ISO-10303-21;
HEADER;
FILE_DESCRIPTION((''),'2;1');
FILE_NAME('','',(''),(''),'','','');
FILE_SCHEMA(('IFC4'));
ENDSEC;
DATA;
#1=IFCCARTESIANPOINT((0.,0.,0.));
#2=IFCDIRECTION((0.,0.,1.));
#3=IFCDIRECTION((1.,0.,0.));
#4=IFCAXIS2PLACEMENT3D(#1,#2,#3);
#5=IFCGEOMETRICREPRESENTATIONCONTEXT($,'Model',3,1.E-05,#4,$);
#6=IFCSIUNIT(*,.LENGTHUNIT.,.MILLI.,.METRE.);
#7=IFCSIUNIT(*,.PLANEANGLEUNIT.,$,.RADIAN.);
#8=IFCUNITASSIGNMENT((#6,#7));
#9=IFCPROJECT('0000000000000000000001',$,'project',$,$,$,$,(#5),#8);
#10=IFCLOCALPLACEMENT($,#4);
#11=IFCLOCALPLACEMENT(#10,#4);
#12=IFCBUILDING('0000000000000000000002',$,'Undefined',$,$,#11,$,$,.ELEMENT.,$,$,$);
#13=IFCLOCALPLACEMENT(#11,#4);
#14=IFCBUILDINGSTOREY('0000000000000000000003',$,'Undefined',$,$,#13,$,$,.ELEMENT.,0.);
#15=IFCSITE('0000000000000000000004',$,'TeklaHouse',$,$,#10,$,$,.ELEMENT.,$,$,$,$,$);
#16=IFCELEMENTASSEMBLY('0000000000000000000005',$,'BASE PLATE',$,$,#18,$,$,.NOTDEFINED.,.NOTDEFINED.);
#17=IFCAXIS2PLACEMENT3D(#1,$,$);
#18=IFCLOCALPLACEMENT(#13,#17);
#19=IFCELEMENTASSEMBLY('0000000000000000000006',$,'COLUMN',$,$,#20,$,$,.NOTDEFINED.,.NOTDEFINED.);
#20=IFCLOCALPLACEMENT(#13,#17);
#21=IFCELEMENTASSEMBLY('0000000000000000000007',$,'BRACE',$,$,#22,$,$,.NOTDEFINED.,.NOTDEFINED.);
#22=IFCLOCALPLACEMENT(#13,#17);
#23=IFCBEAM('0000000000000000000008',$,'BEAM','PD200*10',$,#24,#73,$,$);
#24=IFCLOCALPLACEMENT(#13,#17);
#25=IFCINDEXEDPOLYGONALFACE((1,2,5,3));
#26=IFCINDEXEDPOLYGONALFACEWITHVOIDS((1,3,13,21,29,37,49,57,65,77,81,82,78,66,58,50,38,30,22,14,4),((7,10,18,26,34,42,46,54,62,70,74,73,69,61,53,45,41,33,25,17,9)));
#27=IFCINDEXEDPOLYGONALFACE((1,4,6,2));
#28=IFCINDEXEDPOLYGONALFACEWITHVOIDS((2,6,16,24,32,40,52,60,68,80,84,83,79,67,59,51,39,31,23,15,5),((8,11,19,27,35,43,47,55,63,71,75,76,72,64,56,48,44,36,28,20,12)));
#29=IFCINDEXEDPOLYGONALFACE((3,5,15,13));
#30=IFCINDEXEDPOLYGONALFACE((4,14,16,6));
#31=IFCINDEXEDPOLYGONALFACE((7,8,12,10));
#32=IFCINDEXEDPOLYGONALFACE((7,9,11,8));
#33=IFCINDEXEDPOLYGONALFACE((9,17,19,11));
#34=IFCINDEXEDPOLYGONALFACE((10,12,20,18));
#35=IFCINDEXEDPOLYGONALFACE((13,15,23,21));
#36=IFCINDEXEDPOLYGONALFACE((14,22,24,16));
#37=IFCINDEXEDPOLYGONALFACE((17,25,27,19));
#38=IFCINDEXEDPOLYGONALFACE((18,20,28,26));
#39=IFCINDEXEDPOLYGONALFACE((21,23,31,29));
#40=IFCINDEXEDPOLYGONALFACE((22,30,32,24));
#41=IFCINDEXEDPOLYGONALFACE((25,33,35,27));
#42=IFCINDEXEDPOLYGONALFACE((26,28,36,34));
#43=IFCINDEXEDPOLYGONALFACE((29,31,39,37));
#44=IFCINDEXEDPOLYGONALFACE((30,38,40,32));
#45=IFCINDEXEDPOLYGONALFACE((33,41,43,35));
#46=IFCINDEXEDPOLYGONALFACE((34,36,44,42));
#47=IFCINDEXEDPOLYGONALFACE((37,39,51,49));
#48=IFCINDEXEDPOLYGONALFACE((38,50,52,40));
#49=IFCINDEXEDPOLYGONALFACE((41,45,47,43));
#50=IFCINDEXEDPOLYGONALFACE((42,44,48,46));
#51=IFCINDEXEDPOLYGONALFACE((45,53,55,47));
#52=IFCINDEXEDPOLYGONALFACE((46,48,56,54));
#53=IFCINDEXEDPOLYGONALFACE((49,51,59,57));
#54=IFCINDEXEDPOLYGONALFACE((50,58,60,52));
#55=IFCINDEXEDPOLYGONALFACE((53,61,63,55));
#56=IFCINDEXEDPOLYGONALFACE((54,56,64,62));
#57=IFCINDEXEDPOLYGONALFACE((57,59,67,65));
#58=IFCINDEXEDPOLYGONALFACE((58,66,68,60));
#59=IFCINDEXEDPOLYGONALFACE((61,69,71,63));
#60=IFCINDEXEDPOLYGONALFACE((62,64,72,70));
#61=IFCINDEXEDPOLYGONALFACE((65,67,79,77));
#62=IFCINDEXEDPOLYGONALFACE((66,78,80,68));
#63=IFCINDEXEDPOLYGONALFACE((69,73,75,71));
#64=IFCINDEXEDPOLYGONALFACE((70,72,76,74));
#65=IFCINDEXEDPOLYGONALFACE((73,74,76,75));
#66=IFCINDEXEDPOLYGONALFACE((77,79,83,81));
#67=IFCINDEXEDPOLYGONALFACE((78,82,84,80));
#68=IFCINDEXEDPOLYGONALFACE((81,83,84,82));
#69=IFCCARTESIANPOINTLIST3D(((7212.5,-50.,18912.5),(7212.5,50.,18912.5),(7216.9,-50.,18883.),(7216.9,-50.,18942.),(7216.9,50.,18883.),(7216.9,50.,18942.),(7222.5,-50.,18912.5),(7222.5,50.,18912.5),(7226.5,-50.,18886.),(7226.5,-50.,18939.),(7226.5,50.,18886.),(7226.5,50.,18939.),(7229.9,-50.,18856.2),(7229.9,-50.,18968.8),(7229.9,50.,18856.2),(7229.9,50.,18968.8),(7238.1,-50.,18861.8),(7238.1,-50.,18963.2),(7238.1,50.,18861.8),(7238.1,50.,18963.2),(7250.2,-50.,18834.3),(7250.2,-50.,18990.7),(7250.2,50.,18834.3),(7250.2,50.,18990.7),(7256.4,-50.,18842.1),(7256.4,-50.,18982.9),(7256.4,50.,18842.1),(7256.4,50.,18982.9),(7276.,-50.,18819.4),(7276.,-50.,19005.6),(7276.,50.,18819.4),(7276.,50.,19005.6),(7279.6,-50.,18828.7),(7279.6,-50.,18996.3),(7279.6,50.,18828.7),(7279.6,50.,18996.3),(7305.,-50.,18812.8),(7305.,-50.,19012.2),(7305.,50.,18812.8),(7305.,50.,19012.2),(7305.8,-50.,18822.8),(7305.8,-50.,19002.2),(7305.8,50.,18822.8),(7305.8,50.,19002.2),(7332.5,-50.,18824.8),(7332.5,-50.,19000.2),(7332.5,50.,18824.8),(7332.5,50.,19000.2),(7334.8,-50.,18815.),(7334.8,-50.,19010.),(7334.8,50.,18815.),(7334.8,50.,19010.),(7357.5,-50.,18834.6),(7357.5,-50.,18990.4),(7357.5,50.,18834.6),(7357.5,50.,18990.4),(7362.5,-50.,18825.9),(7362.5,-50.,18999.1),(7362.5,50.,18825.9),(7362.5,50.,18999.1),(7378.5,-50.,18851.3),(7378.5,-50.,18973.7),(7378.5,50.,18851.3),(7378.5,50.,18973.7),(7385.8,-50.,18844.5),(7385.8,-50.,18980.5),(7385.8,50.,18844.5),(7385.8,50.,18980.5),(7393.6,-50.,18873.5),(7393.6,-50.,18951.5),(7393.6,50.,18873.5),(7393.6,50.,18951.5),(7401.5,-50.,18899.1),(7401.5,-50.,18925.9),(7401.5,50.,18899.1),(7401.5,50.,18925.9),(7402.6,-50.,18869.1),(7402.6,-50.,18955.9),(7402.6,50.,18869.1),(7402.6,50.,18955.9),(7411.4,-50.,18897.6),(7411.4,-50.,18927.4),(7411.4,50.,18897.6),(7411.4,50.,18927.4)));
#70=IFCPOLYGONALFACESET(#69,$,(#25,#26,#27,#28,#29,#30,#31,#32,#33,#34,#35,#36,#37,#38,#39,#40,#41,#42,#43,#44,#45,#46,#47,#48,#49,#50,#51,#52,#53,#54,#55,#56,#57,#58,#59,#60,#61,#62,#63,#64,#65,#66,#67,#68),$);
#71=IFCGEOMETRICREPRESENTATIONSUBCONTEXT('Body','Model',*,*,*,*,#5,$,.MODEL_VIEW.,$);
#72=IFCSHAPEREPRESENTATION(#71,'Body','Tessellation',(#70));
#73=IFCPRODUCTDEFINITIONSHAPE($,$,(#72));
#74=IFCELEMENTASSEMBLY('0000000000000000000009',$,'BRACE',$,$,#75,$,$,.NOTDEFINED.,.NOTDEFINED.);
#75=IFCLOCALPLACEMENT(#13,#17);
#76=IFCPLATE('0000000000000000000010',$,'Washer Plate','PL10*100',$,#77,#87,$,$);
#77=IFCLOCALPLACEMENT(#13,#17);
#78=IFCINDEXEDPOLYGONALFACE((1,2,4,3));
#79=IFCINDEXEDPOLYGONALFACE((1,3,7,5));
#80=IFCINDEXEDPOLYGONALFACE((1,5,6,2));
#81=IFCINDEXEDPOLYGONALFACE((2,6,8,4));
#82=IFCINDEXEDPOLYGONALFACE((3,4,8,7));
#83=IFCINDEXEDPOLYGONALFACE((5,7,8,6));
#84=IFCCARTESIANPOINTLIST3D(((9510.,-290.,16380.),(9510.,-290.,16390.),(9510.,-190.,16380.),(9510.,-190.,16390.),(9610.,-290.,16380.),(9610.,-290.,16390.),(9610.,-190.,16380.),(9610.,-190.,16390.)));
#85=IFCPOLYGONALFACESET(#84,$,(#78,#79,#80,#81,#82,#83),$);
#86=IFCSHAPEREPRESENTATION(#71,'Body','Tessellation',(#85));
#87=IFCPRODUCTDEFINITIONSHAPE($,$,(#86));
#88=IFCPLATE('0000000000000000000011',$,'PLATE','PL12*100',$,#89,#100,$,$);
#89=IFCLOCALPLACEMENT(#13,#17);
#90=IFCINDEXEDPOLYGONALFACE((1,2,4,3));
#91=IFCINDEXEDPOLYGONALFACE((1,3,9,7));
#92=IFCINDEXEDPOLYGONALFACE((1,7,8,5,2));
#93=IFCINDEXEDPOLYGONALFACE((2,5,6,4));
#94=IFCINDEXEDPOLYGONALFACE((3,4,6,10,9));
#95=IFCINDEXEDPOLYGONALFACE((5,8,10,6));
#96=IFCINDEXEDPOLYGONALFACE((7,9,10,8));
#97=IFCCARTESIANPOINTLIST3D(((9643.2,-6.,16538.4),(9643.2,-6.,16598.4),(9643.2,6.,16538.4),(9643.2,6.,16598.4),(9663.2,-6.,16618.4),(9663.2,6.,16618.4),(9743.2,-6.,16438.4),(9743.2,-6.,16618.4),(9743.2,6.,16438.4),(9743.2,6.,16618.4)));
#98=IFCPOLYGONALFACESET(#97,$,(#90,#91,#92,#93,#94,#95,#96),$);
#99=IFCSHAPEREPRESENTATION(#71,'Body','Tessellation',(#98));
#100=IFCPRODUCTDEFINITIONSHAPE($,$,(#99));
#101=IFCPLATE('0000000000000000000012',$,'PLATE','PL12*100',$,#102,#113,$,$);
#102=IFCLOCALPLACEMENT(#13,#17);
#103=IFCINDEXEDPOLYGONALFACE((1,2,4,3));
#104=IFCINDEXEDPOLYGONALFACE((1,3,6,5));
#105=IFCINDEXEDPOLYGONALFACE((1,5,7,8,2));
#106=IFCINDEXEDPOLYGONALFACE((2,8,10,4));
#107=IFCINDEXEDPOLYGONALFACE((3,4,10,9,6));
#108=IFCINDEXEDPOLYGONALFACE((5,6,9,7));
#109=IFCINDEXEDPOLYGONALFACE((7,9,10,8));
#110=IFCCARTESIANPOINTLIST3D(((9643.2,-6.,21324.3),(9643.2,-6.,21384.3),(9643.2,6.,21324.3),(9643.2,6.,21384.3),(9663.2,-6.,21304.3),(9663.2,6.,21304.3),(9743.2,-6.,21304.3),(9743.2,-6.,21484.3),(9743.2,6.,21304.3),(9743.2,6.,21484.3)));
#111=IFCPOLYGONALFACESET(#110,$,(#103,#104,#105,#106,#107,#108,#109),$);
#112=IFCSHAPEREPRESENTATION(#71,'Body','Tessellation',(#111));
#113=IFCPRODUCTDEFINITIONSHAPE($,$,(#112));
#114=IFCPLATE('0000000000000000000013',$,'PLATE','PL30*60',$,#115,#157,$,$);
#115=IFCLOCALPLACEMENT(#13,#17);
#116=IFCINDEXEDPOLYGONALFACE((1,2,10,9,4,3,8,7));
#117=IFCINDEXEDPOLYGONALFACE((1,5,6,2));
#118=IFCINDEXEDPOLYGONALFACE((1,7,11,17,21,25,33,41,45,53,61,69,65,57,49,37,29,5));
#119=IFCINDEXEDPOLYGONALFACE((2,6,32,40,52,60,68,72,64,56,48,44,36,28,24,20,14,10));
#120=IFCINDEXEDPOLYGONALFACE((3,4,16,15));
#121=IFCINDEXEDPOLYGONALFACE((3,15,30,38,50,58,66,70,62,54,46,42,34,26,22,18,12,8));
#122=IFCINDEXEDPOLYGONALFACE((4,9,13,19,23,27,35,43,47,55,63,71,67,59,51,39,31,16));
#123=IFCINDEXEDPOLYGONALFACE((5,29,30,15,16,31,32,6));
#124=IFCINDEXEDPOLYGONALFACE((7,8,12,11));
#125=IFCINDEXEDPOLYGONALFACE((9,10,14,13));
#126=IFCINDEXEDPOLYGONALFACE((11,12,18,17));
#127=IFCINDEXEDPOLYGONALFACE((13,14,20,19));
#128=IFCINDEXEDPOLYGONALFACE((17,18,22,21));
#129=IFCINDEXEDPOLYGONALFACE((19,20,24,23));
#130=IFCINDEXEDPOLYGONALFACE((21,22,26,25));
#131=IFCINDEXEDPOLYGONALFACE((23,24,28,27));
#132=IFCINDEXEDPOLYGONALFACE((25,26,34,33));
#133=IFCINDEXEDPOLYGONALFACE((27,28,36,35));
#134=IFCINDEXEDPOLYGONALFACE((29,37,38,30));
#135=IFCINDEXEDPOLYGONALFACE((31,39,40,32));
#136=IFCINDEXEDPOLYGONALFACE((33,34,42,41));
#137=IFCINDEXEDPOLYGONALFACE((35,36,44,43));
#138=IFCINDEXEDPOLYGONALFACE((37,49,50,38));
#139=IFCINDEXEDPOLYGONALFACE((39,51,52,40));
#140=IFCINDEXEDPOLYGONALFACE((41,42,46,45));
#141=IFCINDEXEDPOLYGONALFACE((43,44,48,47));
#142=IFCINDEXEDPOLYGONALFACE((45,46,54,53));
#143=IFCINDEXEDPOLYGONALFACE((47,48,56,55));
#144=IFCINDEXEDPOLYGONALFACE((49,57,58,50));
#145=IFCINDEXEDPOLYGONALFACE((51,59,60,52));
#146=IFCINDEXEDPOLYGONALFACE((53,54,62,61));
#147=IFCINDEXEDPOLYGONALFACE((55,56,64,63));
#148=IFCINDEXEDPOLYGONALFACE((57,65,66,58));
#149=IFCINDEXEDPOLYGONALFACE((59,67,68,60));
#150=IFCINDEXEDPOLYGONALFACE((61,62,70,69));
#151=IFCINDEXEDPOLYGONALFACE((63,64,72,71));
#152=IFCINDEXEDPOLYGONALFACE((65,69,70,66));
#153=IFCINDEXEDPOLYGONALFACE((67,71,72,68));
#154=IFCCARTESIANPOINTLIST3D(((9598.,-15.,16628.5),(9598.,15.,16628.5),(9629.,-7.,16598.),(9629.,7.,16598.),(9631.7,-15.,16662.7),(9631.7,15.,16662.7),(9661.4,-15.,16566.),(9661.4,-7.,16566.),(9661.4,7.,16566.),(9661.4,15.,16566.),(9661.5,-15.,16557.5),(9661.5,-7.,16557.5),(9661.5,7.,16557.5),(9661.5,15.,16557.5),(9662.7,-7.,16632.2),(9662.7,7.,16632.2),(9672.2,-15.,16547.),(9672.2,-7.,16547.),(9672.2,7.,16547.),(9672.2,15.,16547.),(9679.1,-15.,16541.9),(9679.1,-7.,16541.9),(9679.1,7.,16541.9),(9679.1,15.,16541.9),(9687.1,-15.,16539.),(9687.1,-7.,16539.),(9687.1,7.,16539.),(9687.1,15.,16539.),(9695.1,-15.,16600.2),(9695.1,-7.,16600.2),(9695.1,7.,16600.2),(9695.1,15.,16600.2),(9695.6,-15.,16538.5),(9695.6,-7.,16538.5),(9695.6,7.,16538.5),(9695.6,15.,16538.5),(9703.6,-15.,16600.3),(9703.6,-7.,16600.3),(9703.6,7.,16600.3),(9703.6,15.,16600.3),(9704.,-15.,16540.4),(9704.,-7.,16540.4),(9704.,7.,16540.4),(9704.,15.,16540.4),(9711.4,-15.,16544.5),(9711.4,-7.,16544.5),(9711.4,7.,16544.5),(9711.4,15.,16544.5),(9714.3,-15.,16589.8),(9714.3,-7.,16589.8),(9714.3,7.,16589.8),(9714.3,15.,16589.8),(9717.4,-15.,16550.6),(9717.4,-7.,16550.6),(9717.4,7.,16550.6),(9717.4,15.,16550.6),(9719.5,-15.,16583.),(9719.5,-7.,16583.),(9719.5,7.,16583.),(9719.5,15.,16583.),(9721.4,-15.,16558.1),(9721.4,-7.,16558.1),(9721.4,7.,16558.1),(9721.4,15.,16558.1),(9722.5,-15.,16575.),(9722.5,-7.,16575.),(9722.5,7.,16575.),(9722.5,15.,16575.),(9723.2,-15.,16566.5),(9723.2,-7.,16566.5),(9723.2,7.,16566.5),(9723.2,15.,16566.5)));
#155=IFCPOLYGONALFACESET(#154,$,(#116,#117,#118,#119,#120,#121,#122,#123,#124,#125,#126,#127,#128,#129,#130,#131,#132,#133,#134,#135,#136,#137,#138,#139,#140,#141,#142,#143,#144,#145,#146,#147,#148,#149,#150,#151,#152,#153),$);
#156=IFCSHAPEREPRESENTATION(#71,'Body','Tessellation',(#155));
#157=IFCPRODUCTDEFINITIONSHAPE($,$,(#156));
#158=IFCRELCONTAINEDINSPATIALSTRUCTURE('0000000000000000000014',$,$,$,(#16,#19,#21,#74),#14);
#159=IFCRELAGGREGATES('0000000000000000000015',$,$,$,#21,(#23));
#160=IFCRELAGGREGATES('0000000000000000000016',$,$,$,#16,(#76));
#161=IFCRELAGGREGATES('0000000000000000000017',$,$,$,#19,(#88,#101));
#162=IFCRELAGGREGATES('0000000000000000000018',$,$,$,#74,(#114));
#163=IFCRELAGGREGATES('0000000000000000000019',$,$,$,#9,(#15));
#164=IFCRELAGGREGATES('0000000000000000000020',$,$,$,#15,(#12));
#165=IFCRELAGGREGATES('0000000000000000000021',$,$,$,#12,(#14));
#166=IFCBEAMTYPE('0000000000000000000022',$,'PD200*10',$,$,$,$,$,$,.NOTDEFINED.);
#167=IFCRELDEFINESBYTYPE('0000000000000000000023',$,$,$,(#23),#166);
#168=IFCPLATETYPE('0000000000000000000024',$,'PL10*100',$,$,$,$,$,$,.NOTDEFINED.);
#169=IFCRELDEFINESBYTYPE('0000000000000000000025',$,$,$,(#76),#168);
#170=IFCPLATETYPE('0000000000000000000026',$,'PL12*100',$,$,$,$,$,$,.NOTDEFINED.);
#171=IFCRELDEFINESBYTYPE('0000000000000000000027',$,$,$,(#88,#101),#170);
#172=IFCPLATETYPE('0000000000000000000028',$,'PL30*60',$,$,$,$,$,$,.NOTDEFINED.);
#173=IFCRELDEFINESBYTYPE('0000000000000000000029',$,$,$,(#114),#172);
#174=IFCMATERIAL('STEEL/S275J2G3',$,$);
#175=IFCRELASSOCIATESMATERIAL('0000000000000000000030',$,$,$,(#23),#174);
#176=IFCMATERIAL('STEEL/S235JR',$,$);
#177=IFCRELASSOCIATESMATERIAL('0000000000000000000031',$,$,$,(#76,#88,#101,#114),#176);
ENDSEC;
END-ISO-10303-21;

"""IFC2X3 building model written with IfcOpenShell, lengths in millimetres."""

from ifc_helpers import new_model, si_unit, frame, frame_2d, origin_with_axes, origin_2d_with_axis, place, context, subcontext, project, spatial, polyline, circle_curve, parameter, trimmed, segment, composite_curve, rectangle, hollow_circle, outline, extrude, boolean, material, type_object, element, aggregate, save


model = new_model("IFC2X3")

# Units and contexts
model_context = context("Model", 3, precision=1e-05, world=origin_with_axes())
body_context = subcontext(model_context, "Body", "Model", "MODEL_VIEW")
ifc_project = project(units=[si_unit("LENGTHUNIT", "METRE", prefix="MILLI"), si_unit("PLANEANGLEUNIT", "RADIAN")], contexts=[model_context])

# Site, building, storey
site_placement = place(None, origin_with_axes())
site = spatial("IfcSite", under=ifc_project, at=site_placement, Name="TeklaHouse", CompositionType="ELEMENT")
building_placement = place(site_placement, origin_with_axes())
building = spatial("IfcBuilding", under=site, at=building_placement, Name="Undefined", CompositionType="ELEMENT")
storey_placement = place(building_placement, origin_with_axes())
storey = spatial("IfcBuildingStorey", under=building, at=storey_placement, Name="Undefined", CompositionType="ELEMENT", Elevation=0.0)

# Element assembly
assembly_1_placement = place(storey_placement, origin_with_axes())
assembly_1 = element("IfcElementAssembly", 1, at=assembly_1_placement, inside=storey, Name="BASE PLATE", AssemblyPlace="NOTDEFINED", PredefinedType="NOTDEFINED")
ifc_material_1 = material(Name="STEEL/S235JR")

# Element assembly
assembly_2_placement = place(storey_placement, origin_with_axes())
assembly_2 = element("IfcElementAssembly", 2, at=assembly_2_placement, inside=storey, Name="COLUMN", AssemblyPlace="NOTDEFINED", PredefinedType="NOTDEFINED")

# Element assembly, beam
assembly_3_placement = place(storey_placement, origin_with_axes())
assembly_3 = element("IfcElementAssembly", 3, at=assembly_3_placement, inside=storey, Name="BRACE", AssemblyPlace="NOTDEFINED", PredefinedType="NOTDEFINED")
ifc_material_2 = material(Name="STEEL/S275J2G3")
beam_type_1 = type_object("IfcBeamType", Name="PD200*10", PredefinedType="NOTDEFINED")
beam_1_placement = place(assembly_3_placement, frame((7312.5, -50.0, 18912.5), z_axis=(0.0, 0.0, -1.0), x_axis=(0.0, 1.0, 0.0)))
beam_1 = element("IfcBeam", 4, at=beam_1_placement, type_object=beam_type_1, material=ifc_material_2, Name="BEAM", Description="PD200*10", context=body_context, shape_type="SweptSolid", body=[
    extrude(hollow_circle(Radius=100.0, WallThickness=10.0, at=origin_2d_with_axis()), frame((100.0, 0.0, 0.0), z_axis=(-1.0, 0.0, 0.0), x_axis=(0.0, -1.0, 0.0)), (0.0, 0.0, 1.0), 100.0),
])
aggregate(assembly_3, [beam_1])

# Element assembly
assembly_4_placement = place(storey_placement, origin_with_axes())
assembly_4 = element("IfcElementAssembly", 5, at=assembly_4_placement, inside=storey, Name="BRACE", AssemblyPlace="NOTDEFINED", PredefinedType="NOTDEFINED")

# Plates
plate_type_1 = type_object("IfcPlateType", Name="PL10*100", PredefinedType="NOTDEFINED")
plate_1_placement = place(assembly_1_placement, frame((9610.0, -190.0, 16385.0), z_axis=(0.0, 0.0, -1.0), x_axis=(0.0, -1.0, 0.0)))
plate_1 = element("IfcPlate", 6, at=plate_1_placement, type_object=plate_type_1, material=ifc_material_1, Name="Washer Plate", Description="PL10*100", context=body_context, shape_type="SweptSolid", body=[
    extrude(outline(polyline([(0.0, 0.0), (100.0, 0.0), (100.0, 100.0), (0.0, 100.0), (0.0, 0.0)])), frame((0.0, 0.0, -5.0), z_axis=(0.0, 0.0, 1.0), x_axis=(1.0, 0.0, 0.0)), (0.0, 0.0, 1.0), 10.0),
])
plate_type_2 = type_object("IfcPlateType", Name="PL12*100", PredefinedType="NOTDEFINED")
plate_2_placement = place(assembly_2_placement, frame((9643.2, 0.0, 16538.4), z_axis=(0.0, -1.0, 0.0), x_axis=(0.707107, 0.0, -0.707107)))
plate_2 = element("IfcPlate", 7, at=plate_2_placement, type_object=plate_type_2, material=ifc_material_1, Name="PLATE", Description="PL12*100", context=body_context, shape_type="SweptSolid", body=[
    extrude(outline(polyline([(0.0, 0.0), (141.4, 0.0), (14.1, 127.3), (-42.4, 70.7), (-42.4, 42.4), (0.0, 0.0)])), frame((0.0, 0.0, -6.0), z_axis=(0.0, 0.0, 1.0), x_axis=(1.0, 0.0, 0.0)), (0.0, 0.0, 1.0), 12.0),
])
plate_3_placement = place(assembly_2_placement, frame((9663.2, 0.0, 21304.3), z_axis=(0.0, -1.0, 0.0), x_axis=(1.0, 0.0, 0.0)))
plate_3 = element("IfcPlate", 8, at=plate_3_placement, type_object=plate_type_2, material=ifc_material_1, Name="PLATE", Description="PL12*100", context=body_context, shape_type="SweptSolid", body=[
    extrude(outline(polyline([(0.0, 0.0), (80.0, 0.0), (80.0, 180.0), (-20.0, 80.0), (-20.0, 20.0), (0.0, 0.0)])), frame((0.0, 0.0, -6.0), z_axis=(0.0, 0.0, 1.0), x_axis=(1.0, 0.0, 0.0)), (0.0, 0.0, 1.0), 12.0),
])
plate_type_3 = type_object("IfcPlateType", Name="PL30*60", PredefinedType="NOTDEFINED")
plate_4_placement = place(assembly_4_placement, frame((9693.6, 0.0, 16526.0), z_axis=(0.0, -1.0, 0.0), x_axis=(0.701604, 0.0, 0.712567)))
plate_4 = element("IfcPlate", 9, at=plate_4_placement, type_object=plate_type_3, material=ifc_material_1, Name="PLATE", Description="PL30*60", context=body_context, shape_type="CSG", body=[
    boolean("DIFFERENCE", extrude(outline(composite_curve([segment(trimmed(circle_curve(frame_2d((30.0, 30.0), x_axis=(-1.0, 0.0)), 30.0), [parameter(0.0)], [parameter(1.570796)], True, "PARAMETER"), True, "CONTINUOUS"), segment(trimmed(circle_curve(frame_2d((30.0, 30.0), x_axis=(0.0, -1.0)), 30.0), [parameter(0.0)], [parameter(1.570796)], True, "PARAMETER"), True, "CONTINUOUS"), segment(polyline([(60.0, 30.0), (60.0, 45.0), (54.0, 51.0), (54.0, 140.0), (6.0, 140.0), (6.0, 51.0), (0.0, 45.0), (0.0, 30.0)]), True, "CONTINUOUS")], self_intersect=True)), frame((0.0, 0.0, -15.0), z_axis=(0.0, 0.0, 1.0), x_axis=(1.0, 0.0, 0.0)), (0.0, 0.0, 1.0), 30.0), extrude(rectangle(XDim=14.0, YDim=70.0, at=origin_2d_with_axis()), frame((30.0, 96.6, 0.0), z_axis=(0.0, -1.0, 0.0), x_axis=(0.0, 0.0, -1.0)), (0.0, 0.0, 1.0), 106.6)),
])

aggregate(assembly_1, [plate_1])
aggregate(assembly_2, [plate_2, plate_3])

aggregate(assembly_4, [plate_4])

save(model, "model.ifc")
